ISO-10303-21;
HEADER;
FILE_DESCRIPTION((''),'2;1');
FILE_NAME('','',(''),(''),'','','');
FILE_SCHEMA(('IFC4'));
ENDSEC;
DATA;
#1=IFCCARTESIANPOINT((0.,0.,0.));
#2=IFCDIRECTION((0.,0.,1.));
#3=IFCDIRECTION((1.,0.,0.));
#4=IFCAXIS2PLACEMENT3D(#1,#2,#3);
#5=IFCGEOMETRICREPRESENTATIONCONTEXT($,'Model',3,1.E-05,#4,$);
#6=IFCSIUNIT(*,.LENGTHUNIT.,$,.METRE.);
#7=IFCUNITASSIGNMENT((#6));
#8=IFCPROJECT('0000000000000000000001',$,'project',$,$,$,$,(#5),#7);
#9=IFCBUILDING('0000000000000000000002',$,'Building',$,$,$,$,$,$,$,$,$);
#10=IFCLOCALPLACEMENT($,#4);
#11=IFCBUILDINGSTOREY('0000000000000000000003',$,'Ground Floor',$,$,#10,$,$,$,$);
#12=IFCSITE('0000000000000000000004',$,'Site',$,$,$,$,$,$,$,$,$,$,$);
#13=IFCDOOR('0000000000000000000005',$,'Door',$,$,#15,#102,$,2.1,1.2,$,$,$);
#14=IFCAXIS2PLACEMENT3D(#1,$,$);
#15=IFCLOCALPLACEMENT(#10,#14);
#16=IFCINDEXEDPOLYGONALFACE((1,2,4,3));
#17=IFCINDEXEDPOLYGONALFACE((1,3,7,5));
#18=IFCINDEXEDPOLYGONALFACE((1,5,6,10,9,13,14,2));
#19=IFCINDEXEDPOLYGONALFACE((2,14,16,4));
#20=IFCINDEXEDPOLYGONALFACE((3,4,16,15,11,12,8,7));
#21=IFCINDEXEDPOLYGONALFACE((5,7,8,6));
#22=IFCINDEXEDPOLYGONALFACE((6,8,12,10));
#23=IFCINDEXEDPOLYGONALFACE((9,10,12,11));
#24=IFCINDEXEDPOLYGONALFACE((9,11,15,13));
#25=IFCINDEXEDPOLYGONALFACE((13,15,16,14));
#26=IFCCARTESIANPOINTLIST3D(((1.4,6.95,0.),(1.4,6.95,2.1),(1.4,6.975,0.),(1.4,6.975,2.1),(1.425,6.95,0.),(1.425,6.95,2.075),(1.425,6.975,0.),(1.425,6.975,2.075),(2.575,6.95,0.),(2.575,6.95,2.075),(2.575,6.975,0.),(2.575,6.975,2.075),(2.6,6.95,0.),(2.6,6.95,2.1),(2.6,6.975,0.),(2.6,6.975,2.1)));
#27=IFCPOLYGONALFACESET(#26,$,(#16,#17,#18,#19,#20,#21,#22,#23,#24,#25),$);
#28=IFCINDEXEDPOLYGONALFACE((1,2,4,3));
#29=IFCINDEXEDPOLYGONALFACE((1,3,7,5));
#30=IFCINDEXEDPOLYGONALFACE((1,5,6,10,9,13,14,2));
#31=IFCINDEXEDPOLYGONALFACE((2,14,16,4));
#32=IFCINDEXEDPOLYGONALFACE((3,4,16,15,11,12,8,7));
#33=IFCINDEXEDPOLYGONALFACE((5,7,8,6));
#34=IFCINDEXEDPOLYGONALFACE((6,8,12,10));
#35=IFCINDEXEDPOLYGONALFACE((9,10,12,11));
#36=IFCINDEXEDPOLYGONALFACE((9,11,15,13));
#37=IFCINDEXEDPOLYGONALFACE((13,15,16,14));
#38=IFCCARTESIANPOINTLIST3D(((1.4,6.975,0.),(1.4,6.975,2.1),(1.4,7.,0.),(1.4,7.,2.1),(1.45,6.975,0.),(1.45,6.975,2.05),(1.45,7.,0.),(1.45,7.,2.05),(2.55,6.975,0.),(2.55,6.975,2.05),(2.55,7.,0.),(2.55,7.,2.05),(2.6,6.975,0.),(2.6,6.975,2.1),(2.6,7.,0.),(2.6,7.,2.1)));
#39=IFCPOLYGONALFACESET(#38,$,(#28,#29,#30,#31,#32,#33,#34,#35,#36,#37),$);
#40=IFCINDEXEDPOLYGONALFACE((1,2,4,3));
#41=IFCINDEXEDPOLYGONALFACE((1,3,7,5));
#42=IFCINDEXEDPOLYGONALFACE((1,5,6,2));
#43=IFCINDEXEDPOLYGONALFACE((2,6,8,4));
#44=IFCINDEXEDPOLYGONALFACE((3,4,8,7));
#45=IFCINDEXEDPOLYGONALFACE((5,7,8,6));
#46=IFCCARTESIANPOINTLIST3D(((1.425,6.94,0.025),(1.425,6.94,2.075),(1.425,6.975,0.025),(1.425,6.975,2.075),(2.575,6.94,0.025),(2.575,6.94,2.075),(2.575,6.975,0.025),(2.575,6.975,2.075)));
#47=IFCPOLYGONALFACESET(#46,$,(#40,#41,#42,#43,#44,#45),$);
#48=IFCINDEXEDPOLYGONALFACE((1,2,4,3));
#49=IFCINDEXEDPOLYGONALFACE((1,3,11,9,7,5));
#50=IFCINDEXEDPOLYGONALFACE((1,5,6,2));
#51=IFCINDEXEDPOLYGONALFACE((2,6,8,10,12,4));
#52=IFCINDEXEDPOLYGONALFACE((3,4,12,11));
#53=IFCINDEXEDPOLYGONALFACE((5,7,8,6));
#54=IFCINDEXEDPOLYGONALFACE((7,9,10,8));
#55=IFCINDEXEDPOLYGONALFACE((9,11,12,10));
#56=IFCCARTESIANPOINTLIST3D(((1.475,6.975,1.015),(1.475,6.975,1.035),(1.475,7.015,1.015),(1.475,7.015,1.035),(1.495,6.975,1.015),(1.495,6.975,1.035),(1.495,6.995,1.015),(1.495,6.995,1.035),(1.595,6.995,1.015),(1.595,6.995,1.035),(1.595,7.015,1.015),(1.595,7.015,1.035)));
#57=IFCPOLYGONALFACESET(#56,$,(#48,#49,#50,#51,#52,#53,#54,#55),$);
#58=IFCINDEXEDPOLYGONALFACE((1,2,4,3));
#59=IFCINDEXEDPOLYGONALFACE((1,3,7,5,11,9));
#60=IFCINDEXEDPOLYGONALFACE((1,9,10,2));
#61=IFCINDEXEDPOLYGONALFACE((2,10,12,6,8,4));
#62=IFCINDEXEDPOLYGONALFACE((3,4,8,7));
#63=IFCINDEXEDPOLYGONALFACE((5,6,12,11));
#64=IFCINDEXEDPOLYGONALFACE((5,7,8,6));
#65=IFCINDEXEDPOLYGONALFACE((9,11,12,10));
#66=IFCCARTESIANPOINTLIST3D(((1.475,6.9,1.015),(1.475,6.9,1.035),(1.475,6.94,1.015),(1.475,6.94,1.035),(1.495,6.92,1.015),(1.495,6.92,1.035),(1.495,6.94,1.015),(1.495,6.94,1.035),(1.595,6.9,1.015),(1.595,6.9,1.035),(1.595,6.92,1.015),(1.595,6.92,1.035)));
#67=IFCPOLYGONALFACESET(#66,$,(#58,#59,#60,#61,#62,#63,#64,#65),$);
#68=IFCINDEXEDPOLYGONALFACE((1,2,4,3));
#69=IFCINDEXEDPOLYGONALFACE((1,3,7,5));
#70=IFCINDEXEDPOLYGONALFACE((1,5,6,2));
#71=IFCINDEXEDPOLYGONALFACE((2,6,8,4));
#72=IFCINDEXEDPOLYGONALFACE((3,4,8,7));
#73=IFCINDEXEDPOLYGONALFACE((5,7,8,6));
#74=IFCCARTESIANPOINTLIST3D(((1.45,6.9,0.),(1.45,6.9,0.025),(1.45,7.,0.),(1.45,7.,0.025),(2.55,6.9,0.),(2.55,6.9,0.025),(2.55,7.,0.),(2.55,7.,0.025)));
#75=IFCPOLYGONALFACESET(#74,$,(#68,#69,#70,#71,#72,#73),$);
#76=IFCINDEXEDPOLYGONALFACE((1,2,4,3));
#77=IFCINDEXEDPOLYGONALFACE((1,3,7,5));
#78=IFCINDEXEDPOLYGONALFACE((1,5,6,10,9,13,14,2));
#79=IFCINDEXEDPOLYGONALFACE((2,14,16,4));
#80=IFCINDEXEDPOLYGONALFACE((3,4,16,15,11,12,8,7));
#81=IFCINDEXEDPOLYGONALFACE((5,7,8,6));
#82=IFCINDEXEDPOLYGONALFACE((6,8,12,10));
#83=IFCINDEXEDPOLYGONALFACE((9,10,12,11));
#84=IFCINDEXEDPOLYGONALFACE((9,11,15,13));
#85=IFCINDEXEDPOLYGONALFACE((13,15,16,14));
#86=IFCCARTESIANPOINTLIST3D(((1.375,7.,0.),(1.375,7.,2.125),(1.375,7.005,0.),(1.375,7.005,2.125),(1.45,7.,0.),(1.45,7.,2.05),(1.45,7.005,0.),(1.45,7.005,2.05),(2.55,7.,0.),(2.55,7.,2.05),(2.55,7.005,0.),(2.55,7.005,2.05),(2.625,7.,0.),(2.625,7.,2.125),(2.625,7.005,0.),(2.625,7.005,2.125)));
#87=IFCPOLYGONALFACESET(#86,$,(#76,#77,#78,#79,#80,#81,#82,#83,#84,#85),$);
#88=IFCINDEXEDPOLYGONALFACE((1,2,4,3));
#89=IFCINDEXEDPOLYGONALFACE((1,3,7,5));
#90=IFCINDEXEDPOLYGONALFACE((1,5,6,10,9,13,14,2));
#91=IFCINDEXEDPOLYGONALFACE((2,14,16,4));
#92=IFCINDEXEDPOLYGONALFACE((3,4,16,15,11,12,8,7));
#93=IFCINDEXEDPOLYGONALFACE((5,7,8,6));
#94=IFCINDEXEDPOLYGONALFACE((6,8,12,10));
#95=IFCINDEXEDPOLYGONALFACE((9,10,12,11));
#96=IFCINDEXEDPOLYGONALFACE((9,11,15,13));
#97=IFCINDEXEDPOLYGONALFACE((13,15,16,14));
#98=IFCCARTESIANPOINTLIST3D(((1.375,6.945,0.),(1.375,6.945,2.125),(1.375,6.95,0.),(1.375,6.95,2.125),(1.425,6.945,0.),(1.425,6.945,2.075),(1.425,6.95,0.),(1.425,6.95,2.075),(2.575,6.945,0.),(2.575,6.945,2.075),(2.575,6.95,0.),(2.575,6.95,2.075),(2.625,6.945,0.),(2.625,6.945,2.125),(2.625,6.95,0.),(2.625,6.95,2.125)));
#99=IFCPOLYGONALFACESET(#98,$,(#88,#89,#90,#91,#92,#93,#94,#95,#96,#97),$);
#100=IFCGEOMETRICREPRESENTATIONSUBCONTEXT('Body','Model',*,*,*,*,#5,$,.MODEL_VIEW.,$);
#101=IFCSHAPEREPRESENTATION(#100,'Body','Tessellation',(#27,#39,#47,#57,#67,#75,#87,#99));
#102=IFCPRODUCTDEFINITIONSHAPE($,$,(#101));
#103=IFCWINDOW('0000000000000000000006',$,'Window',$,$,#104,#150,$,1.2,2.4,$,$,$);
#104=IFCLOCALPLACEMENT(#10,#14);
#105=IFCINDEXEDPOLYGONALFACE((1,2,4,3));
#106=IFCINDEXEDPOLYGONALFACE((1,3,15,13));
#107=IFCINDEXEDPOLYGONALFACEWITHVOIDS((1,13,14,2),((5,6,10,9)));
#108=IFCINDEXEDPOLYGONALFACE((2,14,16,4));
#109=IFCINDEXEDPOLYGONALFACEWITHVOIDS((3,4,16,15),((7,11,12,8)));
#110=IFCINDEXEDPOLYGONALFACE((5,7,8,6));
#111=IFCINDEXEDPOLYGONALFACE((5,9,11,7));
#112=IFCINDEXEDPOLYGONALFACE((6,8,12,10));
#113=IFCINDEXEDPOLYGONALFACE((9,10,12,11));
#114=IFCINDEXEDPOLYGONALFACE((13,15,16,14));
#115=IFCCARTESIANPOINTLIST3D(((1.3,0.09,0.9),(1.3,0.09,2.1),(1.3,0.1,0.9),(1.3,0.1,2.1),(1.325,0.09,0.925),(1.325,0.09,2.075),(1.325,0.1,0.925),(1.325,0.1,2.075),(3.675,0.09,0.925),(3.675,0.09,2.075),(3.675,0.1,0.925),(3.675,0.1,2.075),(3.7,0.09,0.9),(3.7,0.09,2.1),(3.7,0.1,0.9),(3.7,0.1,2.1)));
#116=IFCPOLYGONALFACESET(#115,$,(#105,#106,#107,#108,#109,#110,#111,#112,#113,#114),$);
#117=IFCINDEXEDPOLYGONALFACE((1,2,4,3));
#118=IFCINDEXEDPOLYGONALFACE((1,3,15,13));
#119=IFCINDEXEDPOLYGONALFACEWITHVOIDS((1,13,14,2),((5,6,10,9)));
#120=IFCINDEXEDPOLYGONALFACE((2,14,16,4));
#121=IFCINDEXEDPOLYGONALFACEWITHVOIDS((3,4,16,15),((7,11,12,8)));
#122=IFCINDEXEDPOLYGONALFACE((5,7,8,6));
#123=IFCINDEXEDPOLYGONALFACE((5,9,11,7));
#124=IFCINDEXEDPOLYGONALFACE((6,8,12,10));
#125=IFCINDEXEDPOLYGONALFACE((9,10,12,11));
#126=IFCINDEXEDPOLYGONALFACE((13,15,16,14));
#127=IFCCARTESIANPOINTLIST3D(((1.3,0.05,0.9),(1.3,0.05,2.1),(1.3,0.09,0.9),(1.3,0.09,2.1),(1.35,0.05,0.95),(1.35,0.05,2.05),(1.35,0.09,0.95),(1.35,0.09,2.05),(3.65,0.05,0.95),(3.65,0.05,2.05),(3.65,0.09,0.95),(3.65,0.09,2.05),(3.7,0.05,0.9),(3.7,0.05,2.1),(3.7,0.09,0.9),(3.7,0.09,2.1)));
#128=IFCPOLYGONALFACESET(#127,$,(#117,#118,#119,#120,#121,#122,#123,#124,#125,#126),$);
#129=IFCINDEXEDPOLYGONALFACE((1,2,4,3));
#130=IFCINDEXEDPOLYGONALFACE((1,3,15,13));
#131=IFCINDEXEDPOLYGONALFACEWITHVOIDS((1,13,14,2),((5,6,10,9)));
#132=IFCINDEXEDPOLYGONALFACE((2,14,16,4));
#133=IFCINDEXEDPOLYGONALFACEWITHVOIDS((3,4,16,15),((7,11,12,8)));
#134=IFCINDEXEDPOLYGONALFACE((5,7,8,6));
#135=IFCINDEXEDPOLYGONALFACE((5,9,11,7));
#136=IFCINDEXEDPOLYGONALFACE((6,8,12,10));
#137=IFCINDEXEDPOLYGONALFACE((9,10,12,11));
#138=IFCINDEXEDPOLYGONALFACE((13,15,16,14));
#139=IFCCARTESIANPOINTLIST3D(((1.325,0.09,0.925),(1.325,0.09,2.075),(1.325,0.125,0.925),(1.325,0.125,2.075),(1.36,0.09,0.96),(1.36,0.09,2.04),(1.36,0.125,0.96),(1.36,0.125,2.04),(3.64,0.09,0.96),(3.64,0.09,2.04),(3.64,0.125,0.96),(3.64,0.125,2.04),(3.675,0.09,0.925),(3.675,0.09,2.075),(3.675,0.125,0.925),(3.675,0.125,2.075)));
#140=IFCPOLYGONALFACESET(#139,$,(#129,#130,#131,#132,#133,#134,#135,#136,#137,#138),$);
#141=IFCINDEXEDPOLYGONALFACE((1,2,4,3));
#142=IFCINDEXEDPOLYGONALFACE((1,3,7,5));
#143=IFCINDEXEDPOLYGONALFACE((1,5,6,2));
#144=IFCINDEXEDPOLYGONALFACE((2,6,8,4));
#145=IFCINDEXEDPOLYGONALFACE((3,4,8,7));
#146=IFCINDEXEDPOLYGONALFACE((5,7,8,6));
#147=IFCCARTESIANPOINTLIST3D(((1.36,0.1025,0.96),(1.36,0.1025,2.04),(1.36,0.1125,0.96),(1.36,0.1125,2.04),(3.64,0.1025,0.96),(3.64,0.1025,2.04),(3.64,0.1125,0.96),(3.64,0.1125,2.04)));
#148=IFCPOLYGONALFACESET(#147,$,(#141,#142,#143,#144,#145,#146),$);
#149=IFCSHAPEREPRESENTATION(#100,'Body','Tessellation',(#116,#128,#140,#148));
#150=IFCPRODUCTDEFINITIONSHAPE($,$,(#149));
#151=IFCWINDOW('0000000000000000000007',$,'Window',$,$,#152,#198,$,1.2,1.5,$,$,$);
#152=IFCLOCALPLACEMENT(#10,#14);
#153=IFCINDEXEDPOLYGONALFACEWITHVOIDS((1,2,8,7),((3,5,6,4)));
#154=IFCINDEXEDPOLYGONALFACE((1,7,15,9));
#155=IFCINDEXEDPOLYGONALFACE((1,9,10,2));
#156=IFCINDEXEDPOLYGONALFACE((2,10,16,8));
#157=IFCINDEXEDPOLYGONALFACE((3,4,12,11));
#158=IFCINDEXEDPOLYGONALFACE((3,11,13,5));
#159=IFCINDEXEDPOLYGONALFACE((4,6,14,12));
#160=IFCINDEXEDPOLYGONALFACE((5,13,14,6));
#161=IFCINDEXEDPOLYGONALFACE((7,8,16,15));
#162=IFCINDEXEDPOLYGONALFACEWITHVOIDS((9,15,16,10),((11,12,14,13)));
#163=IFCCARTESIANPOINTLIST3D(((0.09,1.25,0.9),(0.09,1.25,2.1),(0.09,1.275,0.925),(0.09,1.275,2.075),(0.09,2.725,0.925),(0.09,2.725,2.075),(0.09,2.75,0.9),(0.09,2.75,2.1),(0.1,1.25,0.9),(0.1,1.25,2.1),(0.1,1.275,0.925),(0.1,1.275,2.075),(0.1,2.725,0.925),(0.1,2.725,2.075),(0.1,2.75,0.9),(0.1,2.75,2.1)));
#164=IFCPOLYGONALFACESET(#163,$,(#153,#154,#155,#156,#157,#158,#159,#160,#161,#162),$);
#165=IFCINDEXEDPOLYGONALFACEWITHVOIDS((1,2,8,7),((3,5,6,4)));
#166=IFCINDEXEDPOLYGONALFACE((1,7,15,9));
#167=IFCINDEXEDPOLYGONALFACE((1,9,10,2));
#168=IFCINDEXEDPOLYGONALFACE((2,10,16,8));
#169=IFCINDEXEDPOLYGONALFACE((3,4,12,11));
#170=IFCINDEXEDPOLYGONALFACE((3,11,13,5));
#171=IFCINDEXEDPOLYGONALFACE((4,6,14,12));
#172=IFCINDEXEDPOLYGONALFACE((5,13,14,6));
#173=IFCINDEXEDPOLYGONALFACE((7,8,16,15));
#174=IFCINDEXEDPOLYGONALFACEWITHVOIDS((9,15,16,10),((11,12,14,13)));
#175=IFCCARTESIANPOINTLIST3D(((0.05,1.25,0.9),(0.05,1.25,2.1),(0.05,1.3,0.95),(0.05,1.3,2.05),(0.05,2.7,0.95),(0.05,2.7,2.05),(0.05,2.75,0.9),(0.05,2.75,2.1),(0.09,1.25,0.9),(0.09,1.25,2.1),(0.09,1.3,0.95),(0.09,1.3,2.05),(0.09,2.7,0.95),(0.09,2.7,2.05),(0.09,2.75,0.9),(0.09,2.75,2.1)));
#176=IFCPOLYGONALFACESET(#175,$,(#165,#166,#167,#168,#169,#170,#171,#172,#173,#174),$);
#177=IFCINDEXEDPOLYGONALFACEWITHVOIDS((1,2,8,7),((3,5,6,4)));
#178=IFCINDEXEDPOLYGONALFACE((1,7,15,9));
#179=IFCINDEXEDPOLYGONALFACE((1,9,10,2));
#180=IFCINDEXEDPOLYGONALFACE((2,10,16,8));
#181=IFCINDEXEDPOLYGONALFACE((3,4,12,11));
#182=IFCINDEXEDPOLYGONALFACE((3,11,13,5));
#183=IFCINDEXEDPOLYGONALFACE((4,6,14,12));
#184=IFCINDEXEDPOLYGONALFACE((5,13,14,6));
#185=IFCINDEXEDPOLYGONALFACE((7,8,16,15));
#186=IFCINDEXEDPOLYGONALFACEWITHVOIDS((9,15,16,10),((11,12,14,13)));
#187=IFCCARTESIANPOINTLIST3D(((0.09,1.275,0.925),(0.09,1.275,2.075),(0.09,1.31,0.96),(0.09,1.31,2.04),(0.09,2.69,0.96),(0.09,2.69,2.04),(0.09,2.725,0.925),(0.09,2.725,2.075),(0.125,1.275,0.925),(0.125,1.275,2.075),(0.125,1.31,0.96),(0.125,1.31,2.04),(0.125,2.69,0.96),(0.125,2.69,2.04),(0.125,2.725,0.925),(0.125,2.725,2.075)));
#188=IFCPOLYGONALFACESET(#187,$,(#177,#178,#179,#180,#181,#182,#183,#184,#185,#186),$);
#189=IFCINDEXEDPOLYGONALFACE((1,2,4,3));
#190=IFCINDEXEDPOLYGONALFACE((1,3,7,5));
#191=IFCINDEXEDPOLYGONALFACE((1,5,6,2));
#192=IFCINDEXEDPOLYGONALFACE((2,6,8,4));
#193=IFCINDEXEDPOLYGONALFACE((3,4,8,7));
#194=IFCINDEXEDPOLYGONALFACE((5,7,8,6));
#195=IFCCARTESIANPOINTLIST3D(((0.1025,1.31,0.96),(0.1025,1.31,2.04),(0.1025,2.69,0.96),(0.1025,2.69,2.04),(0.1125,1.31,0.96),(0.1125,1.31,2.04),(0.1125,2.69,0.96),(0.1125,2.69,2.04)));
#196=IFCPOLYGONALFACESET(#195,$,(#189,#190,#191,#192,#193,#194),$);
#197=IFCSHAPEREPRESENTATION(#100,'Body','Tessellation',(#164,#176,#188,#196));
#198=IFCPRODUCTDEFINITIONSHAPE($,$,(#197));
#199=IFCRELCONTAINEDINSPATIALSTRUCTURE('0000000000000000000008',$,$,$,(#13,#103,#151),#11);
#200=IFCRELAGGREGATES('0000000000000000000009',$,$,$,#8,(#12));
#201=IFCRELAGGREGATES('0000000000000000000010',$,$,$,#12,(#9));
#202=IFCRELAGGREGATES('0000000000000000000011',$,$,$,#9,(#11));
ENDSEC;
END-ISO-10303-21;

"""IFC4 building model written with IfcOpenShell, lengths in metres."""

from ifc_helpers import new_model, si_unit, frame, origin_with_axes, place, context, subcontext, project, spatial, line, indexed_curve, outline, extrude, element, save


model = new_model("IFC4")

# Units and contexts
model_context = context("Model", 3, precision=1e-05, world=origin_with_axes())
body_context = subcontext(model_context, "Body", "Model", "MODEL_VIEW")
ifc_project = project(units=[si_unit("LENGTHUNIT", "METRE")], contexts=[model_context])

# Site, building, storey
site = spatial("IfcSite", under=ifc_project, Name="Site")
building = spatial("IfcBuilding", under=site, Name="Building")
storey_placement = place(None, origin_with_axes())
storey = spatial("IfcBuildingStorey", under=building, at=storey_placement, Name="Ground Floor")

# Door
door_1_placement = place(storey_placement, frame((2.6, 7.0, 0.0), z_axis=(0.0, 0.0, 1.0), x_axis=(-1.0, 0.0, 0.0)))
element("IfcDoor", 1, at=door_1_placement, inside=storey, Name="Door", OverallHeight=2.1, OverallWidth=1.2, context=body_context, shape_type="SweptSolid", body=[
    extrude(outline(indexed_curve([(0.0, 0.0), (0.0, 2.1), (1.2, 2.1), (1.2, 0.0), (1.175, 0.0), (1.175, 2.075), (0.025, 2.075), (0.025, 0.0)], segments=[line(1, 2, 3, 4, 5, 6, 7, 8, 1)])), frame((0.0, 0.025, 0.0), z_axis=(0.0, -1.0, 0.0), x_axis=(1.0, 0.0, 0.0)), (0.0, 0.0, -1.0), 0.025),
    extrude(outline(indexed_curve([(0.0, 0.0), (0.0, 2.1), (1.2, 2.1), (1.2, 0.0), (1.15, 0.0), (1.15, 2.05), (0.05, 2.05), (0.05, 0.0)], segments=[line(1, 2, 3, 4, 5, 6, 7, 8, 1)])), frame((0.0, 0.0, 0.0), z_axis=(0.0, -1.0, 0.0), x_axis=(1.0, 0.0, 0.0)), (0.0, 0.0, -1.0), 0.025),
    extrude(outline(indexed_curve([(0.0, 0.0), (1.15, 0.0), (1.15, 0.035), (0.0, 0.035)], segments=[line(1, 2, 3, 4, 1)])), frame((0.025, 0.025, 0.025), z_axis=(0.0, 0.0, 1.0), x_axis=(1.0, 0.0, 0.0)), (0.0, 0.0, 1.0), 2.05),
    extrude(outline(indexed_curve([(0.0, 0.0), (0.0, -0.04), (-0.12, -0.04), (-0.12, -0.02), (-0.02, -0.02), (-0.02, 0.0)], segments=[line(1, 2, 3, 4, 5, 6, 1)])), frame((1.125, 0.025, 1.015), z_axis=(0.0, 0.0, 1.0), x_axis=(1.0, 0.0, 0.0)), (0.0, 0.0, 1.0), 0.02),
    extrude(outline(indexed_curve([(0.0, 0.0), (0.0, 0.04), (-0.12, 0.04), (-0.12, 0.02), (-0.02, 0.02), (-0.02, 0.0)], segments=[line(1, 2, 3, 4, 5, 6, 1)])), frame((1.125, 0.06, 1.015), z_axis=(0.0, 0.0, 1.0), x_axis=(1.0, 0.0, 0.0)), (0.0, 0.0, 1.0), 0.02),
    extrude(outline(indexed_curve([(0.0, 0.0), (1.1, 0.0), (1.1, 0.1), (0.0, 0.1)], segments=[line(1, 2, 3, 4, 1)])), frame((0.05, 0.0, 0.0), z_axis=(0.0, 0.0, 1.0), x_axis=(1.0, 0.0, 0.0)), (0.0, 0.0, 1.0), 0.025),
    extrude(outline(indexed_curve([(0.0, 0.0), (0.0, 2.125), (1.25, 2.125), (1.25, 0.0), (1.175, 0.0), (1.175, 2.05), (0.075, 2.05), (0.075, 0.0)], segments=[line(1, 2, 3, 4, 5, 6, 7, 8, 1)])), frame((-0.025, -0.005, 0.0), z_axis=(0.0, -1.0, 0.0), x_axis=(1.0, 0.0, 0.0)), (0.0, 0.0, -1.0), 0.005),
    extrude(outline(indexed_curve([(0.0, 0.0), (0.0, 2.125), (1.25, 2.125), (1.25, 0.0), (1.2, 0.0), (1.2, 2.075), (0.05, 2.075), (0.05, 0.0)], segments=[line(1, 2, 3, 4, 5, 6, 7, 8, 1)])), frame((-0.025, 0.05, 0.0), z_axis=(0.0, -1.0, 0.0), x_axis=(1.0, 0.0, 0.0)), (0.0, 0.0, -1.0), 0.005),
])

# Windows
window_1_placement = place(storey_placement, frame((1.3, 0.0, 0.9), z_axis=(0.0, 0.0, 1.0), x_axis=(1.0, 0.0, 0.0)))
element("IfcWindow", 2, at=window_1_placement, inside=storey, Name="Window", OverallHeight=1.2, OverallWidth=2.4, context=body_context, shape_type="SweptSolid", body=[
    extrude(outline(indexed_curve([(0.0, 0.0), (2.4, 0.0), (2.4, 1.2), (0.0, 1.2)], segments=[line(1, 2, 3, 4, 1)]), holes=[indexed_curve([(0.025, 0.025), (2.375, 0.025), (2.375, 1.175), (0.025, 1.175)], segments=[line(1, 2, 3, 4, 1)])]), frame((0.0, 0.09, 0.0), z_axis=(0.0, -1.0, 0.0), x_axis=(1.0, 0.0, 0.0)), (0.0, 0.0, -1.0), 0.01),
    extrude(outline(indexed_curve([(0.0, 0.0), (2.4, 0.0), (2.4, 1.2), (0.0, 1.2)], segments=[line(1, 2, 3, 4, 1)]), holes=[indexed_curve([(0.05, 0.05), (2.35, 0.05), (2.35, 1.15), (0.05, 1.15)], segments=[line(1, 2, 3, 4, 1)])]), frame((0.0, 0.05, 0.0), z_axis=(0.0, -1.0, 0.0), x_axis=(1.0, 0.0, 0.0)), (0.0, 0.0, -1.0), 0.04),
    extrude(outline(indexed_curve([(0.0, 0.0), (2.35, 0.0), (2.35, 1.15), (0.0, 1.15)], segments=[line(1, 2, 3, 4, 1)]), holes=[indexed_curve([(0.035, 0.035), (2.315, 0.035), (2.315, 1.115), (0.035, 1.115)], segments=[line(1, 2, 3, 4, 1)])]), frame((0.025, 0.09, 0.025), z_axis=(0.0, -1.0, 0.0), x_axis=(1.0, 0.0, 0.0)), (0.0, 0.0, -1.0), 0.035),
    extrude(outline(indexed_curve([(0.035, 0.035), (2.315, 0.035), (2.315, 1.115), (0.035, 1.115)], segments=[line(1, 2, 3, 4, 1)])), frame((0.025, 0.1025, 0.025), z_axis=(0.0, -1.0, 0.0), x_axis=(1.0, 0.0, 0.0)), (0.0, 0.0, -1.0), 0.01),
])
for number, where, z_axis, x_axis, name in (
    (3, (0.0, 2.75, 0.9), (0.0, 0.0, 1.0), (0.0, -1.0, 0.0), "Window"),
):
    element("IfcWindow", number, at=place(storey_placement, frame(where, z_axis=z_axis, x_axis=x_axis)), inside=storey, Name=name, OverallHeight=1.2, OverallWidth=1.5, context=body_context, shape_type="SweptSolid", body=[
        extrude(outline(indexed_curve([(0.0, 0.0), (1.5, 0.0), (1.5, 1.2), (0.0, 1.2)], segments=[line(1, 2, 3, 4, 1)]), holes=[indexed_curve([(0.025, 0.025), (1.475, 0.025), (1.475, 1.175), (0.025, 1.175)], segments=[line(1, 2, 3, 4, 1)])]), frame((0.0, 0.09, 0.0), z_axis=(0.0, -1.0, 0.0), x_axis=(1.0, 0.0, 0.0)), (0.0, 0.0, -1.0), 0.01),
        extrude(outline(indexed_curve([(0.0, 0.0), (1.5, 0.0), (1.5, 1.2), (0.0, 1.2)], segments=[line(1, 2, 3, 4, 1)]), holes=[indexed_curve([(0.05, 0.05), (1.45, 0.05), (1.45, 1.15), (0.05, 1.15)], segments=[line(1, 2, 3, 4, 1)])]), frame((0.0, 0.05, 0.0), z_axis=(0.0, -1.0, 0.0), x_axis=(1.0, 0.0, 0.0)), (0.0, 0.0, -1.0), 0.04),
        extrude(outline(indexed_curve([(0.0, 0.0), (1.45, 0.0), (1.45, 1.15), (0.0, 1.15)], segments=[line(1, 2, 3, 4, 1)]), holes=[indexed_curve([(0.035, 0.035), (1.415, 0.035), (1.415, 1.115), (0.035, 1.115)], segments=[line(1, 2, 3, 4, 1)])]), frame((0.025, 0.09, 0.025), z_axis=(0.0, -1.0, 0.0), x_axis=(1.0, 0.0, 0.0)), (0.0, 0.0, -1.0), 0.035),
        extrude(outline(indexed_curve([(0.035, 0.035), (1.415, 0.035), (1.415, 1.115), (0.035, 1.115)], segments=[line(1, 2, 3, 4, 1)])), frame((0.025, 0.1025, 0.025), z_axis=(0.0, -1.0, 0.0), x_axis=(1.0, 0.0, 0.0)), (0.0, 0.0, -1.0), 0.01),
    ])

save(model, "model.ifc")
